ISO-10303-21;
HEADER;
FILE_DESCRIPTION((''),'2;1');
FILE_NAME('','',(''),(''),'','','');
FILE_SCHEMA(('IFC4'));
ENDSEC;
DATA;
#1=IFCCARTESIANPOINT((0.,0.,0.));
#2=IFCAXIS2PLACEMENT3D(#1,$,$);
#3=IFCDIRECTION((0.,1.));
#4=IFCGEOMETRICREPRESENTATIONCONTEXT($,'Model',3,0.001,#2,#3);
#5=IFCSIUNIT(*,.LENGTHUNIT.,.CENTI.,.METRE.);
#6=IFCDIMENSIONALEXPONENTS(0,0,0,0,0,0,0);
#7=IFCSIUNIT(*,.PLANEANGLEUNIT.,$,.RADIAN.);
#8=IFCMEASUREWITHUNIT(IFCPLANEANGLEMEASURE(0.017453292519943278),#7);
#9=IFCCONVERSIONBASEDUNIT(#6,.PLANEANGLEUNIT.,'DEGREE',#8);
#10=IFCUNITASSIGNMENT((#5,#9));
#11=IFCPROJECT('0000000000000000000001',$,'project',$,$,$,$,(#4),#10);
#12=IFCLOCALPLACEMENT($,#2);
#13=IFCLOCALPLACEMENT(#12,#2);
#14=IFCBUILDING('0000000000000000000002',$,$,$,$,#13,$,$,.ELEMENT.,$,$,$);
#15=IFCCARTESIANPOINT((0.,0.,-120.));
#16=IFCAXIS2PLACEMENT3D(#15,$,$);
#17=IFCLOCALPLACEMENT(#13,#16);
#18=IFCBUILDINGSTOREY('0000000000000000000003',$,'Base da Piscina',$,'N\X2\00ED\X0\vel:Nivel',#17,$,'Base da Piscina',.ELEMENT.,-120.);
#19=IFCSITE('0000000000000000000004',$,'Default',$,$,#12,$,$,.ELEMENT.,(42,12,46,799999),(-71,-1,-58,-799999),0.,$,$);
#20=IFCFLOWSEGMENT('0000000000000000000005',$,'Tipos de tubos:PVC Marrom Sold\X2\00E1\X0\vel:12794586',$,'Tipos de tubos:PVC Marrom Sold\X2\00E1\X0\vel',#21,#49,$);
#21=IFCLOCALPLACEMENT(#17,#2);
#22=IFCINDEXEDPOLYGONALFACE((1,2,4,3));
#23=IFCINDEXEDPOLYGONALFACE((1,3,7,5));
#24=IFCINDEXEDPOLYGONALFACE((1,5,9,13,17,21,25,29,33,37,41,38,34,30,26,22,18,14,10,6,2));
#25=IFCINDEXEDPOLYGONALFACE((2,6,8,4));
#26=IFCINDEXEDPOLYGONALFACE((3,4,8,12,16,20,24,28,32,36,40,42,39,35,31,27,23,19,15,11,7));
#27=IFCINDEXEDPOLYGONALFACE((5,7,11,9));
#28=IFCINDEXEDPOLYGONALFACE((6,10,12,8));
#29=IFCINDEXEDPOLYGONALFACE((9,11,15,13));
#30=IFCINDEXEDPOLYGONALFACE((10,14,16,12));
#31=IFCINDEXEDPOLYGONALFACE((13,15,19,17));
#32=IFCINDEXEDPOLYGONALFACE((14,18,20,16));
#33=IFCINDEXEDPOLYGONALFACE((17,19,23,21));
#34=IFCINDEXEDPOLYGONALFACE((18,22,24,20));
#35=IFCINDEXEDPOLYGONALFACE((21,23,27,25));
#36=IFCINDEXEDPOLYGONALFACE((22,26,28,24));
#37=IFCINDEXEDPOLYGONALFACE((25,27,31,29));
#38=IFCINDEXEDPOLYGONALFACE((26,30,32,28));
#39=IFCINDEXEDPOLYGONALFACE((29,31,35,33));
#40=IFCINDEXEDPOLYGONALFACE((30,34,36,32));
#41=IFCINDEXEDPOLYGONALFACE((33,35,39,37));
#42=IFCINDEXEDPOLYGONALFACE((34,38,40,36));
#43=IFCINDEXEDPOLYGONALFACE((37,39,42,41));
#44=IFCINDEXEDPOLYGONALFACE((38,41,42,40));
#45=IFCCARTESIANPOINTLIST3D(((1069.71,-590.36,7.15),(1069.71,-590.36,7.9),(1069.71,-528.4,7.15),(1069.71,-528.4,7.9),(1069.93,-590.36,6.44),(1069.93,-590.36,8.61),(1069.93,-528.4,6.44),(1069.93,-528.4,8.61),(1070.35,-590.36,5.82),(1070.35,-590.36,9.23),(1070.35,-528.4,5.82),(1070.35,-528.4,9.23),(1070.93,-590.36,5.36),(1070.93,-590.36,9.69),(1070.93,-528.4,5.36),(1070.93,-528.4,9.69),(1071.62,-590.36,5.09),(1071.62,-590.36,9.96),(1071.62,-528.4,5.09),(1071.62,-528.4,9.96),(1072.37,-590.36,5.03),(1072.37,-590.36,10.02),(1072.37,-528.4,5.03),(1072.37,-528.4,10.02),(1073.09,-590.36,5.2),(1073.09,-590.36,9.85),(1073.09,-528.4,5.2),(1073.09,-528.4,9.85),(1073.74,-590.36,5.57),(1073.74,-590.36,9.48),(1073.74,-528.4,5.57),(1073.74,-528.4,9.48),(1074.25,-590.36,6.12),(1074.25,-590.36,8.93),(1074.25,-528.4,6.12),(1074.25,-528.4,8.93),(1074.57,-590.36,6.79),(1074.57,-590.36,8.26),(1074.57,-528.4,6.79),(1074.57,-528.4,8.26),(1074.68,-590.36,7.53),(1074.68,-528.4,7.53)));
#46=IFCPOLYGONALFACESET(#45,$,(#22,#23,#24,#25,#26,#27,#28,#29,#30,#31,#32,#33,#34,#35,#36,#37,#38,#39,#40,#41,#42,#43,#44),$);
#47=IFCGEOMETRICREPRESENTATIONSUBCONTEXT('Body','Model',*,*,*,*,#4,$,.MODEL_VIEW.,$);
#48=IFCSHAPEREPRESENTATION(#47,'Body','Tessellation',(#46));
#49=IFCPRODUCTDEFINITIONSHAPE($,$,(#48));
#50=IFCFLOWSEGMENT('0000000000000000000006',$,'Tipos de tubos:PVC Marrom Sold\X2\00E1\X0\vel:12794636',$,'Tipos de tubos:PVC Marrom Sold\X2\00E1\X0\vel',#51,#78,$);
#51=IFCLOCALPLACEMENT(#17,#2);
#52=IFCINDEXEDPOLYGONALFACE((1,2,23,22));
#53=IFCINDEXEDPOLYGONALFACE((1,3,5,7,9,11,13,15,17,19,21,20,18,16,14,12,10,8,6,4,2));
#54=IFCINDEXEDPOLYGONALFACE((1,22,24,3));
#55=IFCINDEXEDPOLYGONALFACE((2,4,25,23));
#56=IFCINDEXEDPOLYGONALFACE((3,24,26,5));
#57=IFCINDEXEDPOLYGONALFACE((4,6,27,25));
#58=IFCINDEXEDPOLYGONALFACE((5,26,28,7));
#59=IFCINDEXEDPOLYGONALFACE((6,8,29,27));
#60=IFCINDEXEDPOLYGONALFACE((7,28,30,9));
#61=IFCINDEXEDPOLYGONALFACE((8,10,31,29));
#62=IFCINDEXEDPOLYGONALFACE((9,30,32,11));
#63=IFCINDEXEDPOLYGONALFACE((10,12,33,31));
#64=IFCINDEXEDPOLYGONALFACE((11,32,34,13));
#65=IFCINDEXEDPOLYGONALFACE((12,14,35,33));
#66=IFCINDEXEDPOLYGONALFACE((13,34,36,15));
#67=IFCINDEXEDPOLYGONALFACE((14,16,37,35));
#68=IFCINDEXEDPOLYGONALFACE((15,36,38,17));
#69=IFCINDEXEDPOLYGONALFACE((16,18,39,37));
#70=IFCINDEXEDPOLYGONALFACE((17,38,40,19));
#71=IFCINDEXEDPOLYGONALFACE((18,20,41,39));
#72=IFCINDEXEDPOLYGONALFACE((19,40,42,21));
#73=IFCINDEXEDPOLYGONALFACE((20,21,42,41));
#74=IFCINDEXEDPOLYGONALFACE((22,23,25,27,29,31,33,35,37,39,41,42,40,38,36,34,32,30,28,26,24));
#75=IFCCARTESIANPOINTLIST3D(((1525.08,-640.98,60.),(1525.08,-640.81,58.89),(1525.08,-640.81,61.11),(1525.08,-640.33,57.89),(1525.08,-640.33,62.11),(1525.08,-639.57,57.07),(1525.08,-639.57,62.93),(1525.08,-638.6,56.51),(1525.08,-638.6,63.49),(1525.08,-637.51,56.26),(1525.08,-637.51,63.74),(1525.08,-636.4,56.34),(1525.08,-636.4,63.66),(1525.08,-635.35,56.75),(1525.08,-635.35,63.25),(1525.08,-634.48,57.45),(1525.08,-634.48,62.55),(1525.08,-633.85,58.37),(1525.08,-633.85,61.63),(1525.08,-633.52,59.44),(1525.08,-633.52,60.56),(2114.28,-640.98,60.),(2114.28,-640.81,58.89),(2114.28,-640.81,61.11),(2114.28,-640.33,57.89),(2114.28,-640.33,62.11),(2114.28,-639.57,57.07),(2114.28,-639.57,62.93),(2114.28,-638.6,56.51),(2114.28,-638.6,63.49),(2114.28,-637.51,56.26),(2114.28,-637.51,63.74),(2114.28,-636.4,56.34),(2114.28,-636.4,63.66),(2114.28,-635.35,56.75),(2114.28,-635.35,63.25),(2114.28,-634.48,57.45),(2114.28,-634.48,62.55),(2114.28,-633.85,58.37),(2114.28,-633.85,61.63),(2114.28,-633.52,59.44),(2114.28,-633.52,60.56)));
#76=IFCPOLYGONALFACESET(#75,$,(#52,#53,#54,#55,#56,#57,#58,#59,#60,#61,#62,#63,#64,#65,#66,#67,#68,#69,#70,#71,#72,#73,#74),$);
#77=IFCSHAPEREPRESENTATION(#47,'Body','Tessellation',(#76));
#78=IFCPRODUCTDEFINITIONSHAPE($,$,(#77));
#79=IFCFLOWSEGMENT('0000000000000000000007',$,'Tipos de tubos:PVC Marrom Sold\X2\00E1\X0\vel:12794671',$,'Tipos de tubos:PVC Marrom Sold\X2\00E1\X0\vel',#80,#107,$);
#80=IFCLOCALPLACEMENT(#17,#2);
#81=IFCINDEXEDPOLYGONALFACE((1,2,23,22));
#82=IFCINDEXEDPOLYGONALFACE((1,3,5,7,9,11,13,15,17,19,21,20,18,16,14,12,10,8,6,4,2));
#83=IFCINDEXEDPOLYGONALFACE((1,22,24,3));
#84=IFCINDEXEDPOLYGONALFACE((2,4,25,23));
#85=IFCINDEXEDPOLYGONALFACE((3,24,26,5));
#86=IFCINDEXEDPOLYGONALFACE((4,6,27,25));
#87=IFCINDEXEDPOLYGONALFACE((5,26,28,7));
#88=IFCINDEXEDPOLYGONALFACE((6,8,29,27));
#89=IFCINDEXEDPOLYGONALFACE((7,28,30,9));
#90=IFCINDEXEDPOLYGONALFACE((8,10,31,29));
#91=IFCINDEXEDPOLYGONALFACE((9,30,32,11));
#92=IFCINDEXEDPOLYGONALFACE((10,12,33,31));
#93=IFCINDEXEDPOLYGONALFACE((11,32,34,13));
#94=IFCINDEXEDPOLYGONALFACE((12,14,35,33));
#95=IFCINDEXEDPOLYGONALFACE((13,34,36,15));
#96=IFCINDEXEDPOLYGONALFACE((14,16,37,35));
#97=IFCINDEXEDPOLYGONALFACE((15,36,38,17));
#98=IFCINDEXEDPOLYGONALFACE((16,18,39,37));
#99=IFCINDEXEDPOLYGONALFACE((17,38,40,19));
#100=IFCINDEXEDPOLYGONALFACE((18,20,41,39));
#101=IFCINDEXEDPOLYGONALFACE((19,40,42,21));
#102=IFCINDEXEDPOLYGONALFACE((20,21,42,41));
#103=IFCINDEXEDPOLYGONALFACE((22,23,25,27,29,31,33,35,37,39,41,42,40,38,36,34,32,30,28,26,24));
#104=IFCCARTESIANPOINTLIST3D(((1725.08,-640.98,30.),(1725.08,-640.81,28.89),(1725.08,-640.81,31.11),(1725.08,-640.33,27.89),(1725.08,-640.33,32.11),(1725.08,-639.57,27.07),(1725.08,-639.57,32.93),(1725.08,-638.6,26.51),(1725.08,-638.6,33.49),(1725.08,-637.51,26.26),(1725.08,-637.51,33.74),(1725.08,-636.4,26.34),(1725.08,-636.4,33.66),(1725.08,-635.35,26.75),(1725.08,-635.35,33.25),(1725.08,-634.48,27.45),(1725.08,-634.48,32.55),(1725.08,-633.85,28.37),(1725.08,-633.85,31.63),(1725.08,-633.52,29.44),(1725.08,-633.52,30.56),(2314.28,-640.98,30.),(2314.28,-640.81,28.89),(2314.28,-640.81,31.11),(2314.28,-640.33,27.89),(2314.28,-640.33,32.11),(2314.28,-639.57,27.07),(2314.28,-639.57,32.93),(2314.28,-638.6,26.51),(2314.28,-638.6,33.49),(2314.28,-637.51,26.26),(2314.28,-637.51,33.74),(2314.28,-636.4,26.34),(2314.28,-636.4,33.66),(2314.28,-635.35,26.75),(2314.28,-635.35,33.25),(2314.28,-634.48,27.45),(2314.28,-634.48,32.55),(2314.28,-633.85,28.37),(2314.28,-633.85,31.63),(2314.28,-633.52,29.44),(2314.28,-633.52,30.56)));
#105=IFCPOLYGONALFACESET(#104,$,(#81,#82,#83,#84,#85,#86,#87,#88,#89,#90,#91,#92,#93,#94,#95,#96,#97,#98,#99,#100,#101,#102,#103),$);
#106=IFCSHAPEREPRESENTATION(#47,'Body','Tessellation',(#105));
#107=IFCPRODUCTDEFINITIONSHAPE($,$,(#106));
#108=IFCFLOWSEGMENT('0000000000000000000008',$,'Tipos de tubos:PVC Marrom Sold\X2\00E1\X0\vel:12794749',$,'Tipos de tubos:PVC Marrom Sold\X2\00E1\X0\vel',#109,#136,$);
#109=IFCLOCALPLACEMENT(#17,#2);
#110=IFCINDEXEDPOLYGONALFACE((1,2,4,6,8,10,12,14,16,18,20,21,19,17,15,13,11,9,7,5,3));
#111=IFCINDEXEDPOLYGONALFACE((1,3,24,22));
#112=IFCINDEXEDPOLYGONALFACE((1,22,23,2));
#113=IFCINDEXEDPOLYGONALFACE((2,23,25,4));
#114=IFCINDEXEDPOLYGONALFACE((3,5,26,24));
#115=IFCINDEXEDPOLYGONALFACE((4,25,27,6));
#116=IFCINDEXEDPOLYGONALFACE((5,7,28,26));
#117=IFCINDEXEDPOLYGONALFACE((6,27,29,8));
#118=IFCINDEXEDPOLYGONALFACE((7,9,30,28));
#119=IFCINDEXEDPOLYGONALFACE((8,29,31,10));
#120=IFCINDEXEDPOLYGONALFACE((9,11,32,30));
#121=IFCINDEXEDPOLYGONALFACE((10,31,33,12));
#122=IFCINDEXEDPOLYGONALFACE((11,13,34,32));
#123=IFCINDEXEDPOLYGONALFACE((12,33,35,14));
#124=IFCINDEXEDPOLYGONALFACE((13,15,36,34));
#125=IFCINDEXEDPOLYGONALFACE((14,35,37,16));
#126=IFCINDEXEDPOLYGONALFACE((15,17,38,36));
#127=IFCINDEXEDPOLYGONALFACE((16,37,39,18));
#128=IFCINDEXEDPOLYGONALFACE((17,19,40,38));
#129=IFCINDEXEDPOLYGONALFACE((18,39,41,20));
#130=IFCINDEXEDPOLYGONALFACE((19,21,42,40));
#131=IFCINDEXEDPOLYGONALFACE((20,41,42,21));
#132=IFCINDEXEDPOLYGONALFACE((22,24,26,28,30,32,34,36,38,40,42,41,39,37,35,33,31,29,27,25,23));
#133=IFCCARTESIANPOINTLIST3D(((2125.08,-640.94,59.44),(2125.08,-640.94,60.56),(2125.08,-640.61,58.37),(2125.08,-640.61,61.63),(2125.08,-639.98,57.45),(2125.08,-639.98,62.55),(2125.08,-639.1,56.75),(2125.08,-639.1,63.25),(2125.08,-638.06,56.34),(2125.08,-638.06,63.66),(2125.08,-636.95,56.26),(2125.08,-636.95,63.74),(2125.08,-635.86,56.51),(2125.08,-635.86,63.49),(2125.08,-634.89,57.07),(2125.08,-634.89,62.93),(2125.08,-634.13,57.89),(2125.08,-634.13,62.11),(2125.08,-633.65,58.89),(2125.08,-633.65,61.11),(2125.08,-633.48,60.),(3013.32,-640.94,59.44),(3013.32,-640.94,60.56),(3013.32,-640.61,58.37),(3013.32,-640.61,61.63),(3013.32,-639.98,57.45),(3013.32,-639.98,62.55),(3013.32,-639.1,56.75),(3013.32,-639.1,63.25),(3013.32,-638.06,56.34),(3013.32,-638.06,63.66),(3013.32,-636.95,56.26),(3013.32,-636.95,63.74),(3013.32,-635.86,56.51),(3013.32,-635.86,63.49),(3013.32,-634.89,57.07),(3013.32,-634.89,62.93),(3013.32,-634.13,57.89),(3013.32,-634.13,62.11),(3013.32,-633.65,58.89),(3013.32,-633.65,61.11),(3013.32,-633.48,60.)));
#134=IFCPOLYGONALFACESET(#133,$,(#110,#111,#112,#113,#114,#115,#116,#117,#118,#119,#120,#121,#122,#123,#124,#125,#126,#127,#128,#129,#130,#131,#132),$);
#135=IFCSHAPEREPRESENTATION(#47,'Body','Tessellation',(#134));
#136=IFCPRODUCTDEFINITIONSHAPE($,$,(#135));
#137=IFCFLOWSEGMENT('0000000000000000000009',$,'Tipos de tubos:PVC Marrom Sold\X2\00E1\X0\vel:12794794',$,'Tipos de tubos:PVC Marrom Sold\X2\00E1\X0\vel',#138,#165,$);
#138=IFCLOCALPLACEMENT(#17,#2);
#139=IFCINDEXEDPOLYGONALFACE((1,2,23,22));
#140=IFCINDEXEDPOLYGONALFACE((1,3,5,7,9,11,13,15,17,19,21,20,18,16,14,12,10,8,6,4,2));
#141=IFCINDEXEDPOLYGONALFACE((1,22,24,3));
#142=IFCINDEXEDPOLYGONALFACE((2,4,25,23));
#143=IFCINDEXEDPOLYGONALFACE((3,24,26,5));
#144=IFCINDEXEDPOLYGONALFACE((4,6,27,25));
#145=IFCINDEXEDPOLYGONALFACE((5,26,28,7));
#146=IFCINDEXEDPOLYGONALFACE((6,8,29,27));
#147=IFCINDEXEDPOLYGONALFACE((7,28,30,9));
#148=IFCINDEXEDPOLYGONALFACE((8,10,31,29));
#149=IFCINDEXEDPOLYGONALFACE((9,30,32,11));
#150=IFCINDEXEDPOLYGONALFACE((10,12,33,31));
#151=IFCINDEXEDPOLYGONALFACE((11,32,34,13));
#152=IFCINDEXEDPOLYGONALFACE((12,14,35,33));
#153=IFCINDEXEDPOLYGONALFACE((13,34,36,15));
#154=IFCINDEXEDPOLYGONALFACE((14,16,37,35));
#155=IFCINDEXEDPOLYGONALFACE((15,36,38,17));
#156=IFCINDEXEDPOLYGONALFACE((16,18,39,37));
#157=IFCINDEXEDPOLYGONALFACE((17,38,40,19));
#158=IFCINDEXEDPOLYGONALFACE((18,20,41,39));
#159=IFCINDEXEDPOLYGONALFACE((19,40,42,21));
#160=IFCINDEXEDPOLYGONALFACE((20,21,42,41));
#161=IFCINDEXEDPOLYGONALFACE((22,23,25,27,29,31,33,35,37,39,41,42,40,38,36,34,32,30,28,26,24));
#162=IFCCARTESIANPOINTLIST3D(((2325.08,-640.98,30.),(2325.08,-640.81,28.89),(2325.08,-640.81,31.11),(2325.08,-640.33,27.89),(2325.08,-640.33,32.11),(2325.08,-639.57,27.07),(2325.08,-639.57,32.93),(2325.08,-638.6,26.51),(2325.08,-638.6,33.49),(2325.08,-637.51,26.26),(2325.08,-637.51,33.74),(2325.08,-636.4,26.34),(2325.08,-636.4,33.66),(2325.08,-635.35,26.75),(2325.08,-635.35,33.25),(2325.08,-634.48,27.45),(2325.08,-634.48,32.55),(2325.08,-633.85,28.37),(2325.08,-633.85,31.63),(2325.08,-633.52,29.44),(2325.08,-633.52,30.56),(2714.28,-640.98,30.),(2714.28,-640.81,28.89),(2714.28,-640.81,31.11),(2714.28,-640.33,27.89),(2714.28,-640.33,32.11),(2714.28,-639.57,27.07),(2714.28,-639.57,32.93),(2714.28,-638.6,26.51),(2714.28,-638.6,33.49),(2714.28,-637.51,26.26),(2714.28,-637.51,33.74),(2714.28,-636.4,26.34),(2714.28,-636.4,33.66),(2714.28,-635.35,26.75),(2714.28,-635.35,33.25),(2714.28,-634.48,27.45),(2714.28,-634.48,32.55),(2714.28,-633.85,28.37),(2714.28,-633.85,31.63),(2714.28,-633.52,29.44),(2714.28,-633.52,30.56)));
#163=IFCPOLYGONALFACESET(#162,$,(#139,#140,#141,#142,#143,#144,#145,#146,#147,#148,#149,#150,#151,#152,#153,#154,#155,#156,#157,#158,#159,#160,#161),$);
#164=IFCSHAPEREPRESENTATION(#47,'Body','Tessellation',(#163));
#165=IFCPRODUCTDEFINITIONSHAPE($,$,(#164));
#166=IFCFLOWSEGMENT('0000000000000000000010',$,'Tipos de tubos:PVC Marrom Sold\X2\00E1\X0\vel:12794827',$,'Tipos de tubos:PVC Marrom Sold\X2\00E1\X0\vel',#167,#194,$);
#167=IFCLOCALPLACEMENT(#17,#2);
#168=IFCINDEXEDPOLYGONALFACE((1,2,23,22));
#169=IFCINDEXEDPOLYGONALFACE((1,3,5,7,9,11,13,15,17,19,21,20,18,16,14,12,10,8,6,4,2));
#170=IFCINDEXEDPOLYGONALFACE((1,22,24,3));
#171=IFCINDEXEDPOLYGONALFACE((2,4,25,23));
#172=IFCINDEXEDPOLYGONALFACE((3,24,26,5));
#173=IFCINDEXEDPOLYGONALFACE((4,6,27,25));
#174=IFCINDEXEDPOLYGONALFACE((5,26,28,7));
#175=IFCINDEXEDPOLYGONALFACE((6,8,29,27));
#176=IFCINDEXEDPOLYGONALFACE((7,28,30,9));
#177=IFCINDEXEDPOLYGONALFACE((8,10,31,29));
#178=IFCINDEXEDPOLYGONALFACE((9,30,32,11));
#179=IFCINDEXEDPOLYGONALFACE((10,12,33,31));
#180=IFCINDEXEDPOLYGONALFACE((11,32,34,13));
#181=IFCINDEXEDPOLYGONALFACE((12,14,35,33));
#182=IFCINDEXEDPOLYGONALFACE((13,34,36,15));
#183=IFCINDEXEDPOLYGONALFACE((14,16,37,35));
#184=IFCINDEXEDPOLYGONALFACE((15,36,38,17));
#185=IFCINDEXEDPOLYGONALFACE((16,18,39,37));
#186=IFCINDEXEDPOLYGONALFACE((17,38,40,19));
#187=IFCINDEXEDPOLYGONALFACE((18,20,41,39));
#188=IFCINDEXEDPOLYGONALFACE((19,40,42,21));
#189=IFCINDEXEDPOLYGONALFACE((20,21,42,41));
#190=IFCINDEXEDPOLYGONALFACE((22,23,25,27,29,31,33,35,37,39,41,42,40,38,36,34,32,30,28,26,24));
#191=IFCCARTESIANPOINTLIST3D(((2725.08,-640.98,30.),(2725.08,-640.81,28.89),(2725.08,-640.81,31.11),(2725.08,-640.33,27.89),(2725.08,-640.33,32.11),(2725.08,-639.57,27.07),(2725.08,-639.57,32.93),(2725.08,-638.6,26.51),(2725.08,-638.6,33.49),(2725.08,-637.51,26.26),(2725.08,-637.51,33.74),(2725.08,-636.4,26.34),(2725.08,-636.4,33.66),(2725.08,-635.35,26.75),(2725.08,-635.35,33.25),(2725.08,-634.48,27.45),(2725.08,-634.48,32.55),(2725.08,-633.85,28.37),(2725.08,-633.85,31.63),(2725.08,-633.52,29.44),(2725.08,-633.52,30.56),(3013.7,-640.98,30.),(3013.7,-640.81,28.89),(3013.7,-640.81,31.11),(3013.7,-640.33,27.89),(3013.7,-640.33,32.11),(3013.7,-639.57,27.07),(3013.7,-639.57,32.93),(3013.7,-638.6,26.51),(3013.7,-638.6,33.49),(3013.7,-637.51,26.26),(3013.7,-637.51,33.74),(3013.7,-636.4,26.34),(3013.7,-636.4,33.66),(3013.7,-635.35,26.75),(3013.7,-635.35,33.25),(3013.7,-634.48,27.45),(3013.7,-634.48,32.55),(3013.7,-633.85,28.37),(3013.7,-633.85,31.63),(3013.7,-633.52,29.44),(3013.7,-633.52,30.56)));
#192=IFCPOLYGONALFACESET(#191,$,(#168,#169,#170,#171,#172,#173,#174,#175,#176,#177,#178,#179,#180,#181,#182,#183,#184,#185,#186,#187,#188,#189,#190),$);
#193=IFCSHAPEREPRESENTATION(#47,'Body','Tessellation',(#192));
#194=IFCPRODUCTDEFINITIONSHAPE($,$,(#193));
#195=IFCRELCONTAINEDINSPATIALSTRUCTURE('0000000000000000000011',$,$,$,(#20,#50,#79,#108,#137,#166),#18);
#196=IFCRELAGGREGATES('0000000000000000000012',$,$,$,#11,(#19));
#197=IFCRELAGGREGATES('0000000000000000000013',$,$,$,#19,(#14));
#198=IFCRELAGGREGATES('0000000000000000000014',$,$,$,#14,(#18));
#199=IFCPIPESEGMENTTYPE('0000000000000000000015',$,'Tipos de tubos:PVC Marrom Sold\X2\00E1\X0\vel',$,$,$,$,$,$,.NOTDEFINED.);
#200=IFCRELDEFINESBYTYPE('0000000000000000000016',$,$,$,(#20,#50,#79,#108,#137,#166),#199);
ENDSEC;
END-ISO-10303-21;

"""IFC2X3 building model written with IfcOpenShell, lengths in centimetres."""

from ifc_helpers import new_model, entity, si_unit, converted_unit, direction, frame, frame_2d, origin, origin_2d_with_axis, place, context, subcontext, project, spatial, circle, extrude, type_object, element, save


model = new_model("IFC2X3")

# Units and contexts
model_context = context("Model", 3, precision=0.001, world=origin(), true_north=direction((0.0, 1.0)))
body_context = subcontext(model_context, "Body", "Model", "MODEL_VIEW")
ifc_project = project(units=[si_unit("LENGTHUNIT", "METRE", prefix="CENTI"), converted_unit("PLANEANGLEUNIT", "DEGREE", entity("IfcPlaneAngleMeasure", 0.017453292519943278), si_unit("PLANEANGLEUNIT", "RADIAN"), dimensions=[0, 0, 0, 0, 0, 0, 0])], contexts=[model_context])

# Site, building, storey
site_placement = place(None, origin())
site = spatial("IfcSite", under=ifc_project, at=site_placement, Name="Default", CompositionType="ELEMENT", RefLatitude=(42, 12, 46, 799999), RefLongitude=(-71, -1, -58, -799999), RefElevation=0.0)
building_placement = place(site_placement, origin())
building = spatial("IfcBuilding", under=site, at=building_placement, CompositionType="ELEMENT")
storey_placement = place(building_placement, frame((0.0, 0.0, -120.0)))
storey = spatial("IfcBuildingStorey", under=building, at=storey_placement, Name="Base da Piscina", ObjectType="Nível:Nivel", LongName="Base da Piscina", CompositionType="ELEMENT", Elevation=-120.0)

# Flow segments
pipe_segment_type = type_object("IfcPipeSegmentType", Name="Tipos de tubos:PVC Marrom Soldável", PredefinedType="NOTDEFINED")
flow_segment_1_placement = place(storey_placement, origin())
element("IfcFlowSegment", 1, at=flow_segment_1_placement, inside=storey, type_object=pipe_segment_type, Name="Tipos de tubos:PVC Marrom Soldável:12794586", ObjectType="Tipos de tubos:PVC Marrom Soldável", context=body_context, shape_type="SweptSolid", body=[
    extrude(circle(Radius=2.5, at=origin_2d_with_axis()), frame((1072.18, -590.36, 7.53), z_axis=(0.0, 1.0, 0.0), x_axis=(1.0, 0.0, 0.0)), (0.0, 0.0, 1.0), 61.96),
])
flow_segment_2_placement = place(storey_placement, origin())
element("IfcFlowSegment", 2, at=flow_segment_2_placement, inside=storey, type_object=pipe_segment_type, Name="Tipos de tubos:PVC Marrom Soldável:12794636", ObjectType="Tipos de tubos:PVC Marrom Soldável", context=body_context, shape_type="SweptSolid", body=[
    extrude(circle(Radius=3.75, at=origin_2d_with_axis()), frame((1525.08, -637.23, 60.0), z_axis=(1.0, 0.0, 0.0), x_axis=(0.0, -1.0, 0.0)), (0.0, 0.0, 1.0), 589.2),
])
flow_segment_3_placement = place(storey_placement, origin())
element("IfcFlowSegment", 3, at=flow_segment_3_placement, inside=storey, type_object=pipe_segment_type, Name="Tipos de tubos:PVC Marrom Soldável:12794671", ObjectType="Tipos de tubos:PVC Marrom Soldável", context=body_context, shape_type="SweptSolid", body=[
    extrude(circle(Radius=3.75, at=origin_2d_with_axis()), frame((1725.08, -637.23, 30.0), z_axis=(1.0, 0.0, 0.0), x_axis=(0.0, -1.0, 0.0)), (0.0, 0.0, 1.0), 589.2),
])
flow_segment_4_placement = place(storey_placement, origin())
element("IfcFlowSegment", 4, at=flow_segment_4_placement, inside=storey, type_object=pipe_segment_type, Name="Tipos de tubos:PVC Marrom Soldável:12794749", ObjectType="Tipos de tubos:PVC Marrom Soldável", context=body_context, shape_type="SweptSolid", body=[
    extrude(circle(Radius=3.75, at=frame_2d((0.0, 0.0), x_axis=(1.0, 0.0))), frame((2125.08, -637.23, 60.0), z_axis=(1.0, 0.0, 0.0), x_axis=(0.0, 1.0, 0.0)), (0.0, 0.0, 1.0), 888.24),
])
flow_segment_5_placement = place(storey_placement, origin())
element("IfcFlowSegment", 5, at=flow_segment_5_placement, inside=storey, type_object=pipe_segment_type, Name="Tipos de tubos:PVC Marrom Soldável:12794794", ObjectType="Tipos de tubos:PVC Marrom Soldável", context=body_context, shape_type="SweptSolid", body=[
    extrude(circle(Radius=3.75, at=origin_2d_with_axis()), frame((2325.08, -637.23, 30.0), z_axis=(1.0, 0.0, 0.0), x_axis=(0.0, -1.0, 0.0)), (0.0, 0.0, 1.0), 389.2),
])
flow_segment_6_placement = place(storey_placement, origin())
element("IfcFlowSegment", 6, at=flow_segment_6_placement, inside=storey, type_object=pipe_segment_type, Name="Tipos de tubos:PVC Marrom Soldável:12794827", ObjectType="Tipos de tubos:PVC Marrom Soldável", context=body_context, shape_type="SweptSolid", body=[
    extrude(circle(Radius=3.75, at=origin_2d_with_axis()), frame((2725.08, -637.23, 30.0), z_axis=(1.0, 0.0, 0.0), x_axis=(0.0, -1.0, 0.0)), (0.0, 0.0, 1.0), 288.62),
])

save(model, "model.ifc")
